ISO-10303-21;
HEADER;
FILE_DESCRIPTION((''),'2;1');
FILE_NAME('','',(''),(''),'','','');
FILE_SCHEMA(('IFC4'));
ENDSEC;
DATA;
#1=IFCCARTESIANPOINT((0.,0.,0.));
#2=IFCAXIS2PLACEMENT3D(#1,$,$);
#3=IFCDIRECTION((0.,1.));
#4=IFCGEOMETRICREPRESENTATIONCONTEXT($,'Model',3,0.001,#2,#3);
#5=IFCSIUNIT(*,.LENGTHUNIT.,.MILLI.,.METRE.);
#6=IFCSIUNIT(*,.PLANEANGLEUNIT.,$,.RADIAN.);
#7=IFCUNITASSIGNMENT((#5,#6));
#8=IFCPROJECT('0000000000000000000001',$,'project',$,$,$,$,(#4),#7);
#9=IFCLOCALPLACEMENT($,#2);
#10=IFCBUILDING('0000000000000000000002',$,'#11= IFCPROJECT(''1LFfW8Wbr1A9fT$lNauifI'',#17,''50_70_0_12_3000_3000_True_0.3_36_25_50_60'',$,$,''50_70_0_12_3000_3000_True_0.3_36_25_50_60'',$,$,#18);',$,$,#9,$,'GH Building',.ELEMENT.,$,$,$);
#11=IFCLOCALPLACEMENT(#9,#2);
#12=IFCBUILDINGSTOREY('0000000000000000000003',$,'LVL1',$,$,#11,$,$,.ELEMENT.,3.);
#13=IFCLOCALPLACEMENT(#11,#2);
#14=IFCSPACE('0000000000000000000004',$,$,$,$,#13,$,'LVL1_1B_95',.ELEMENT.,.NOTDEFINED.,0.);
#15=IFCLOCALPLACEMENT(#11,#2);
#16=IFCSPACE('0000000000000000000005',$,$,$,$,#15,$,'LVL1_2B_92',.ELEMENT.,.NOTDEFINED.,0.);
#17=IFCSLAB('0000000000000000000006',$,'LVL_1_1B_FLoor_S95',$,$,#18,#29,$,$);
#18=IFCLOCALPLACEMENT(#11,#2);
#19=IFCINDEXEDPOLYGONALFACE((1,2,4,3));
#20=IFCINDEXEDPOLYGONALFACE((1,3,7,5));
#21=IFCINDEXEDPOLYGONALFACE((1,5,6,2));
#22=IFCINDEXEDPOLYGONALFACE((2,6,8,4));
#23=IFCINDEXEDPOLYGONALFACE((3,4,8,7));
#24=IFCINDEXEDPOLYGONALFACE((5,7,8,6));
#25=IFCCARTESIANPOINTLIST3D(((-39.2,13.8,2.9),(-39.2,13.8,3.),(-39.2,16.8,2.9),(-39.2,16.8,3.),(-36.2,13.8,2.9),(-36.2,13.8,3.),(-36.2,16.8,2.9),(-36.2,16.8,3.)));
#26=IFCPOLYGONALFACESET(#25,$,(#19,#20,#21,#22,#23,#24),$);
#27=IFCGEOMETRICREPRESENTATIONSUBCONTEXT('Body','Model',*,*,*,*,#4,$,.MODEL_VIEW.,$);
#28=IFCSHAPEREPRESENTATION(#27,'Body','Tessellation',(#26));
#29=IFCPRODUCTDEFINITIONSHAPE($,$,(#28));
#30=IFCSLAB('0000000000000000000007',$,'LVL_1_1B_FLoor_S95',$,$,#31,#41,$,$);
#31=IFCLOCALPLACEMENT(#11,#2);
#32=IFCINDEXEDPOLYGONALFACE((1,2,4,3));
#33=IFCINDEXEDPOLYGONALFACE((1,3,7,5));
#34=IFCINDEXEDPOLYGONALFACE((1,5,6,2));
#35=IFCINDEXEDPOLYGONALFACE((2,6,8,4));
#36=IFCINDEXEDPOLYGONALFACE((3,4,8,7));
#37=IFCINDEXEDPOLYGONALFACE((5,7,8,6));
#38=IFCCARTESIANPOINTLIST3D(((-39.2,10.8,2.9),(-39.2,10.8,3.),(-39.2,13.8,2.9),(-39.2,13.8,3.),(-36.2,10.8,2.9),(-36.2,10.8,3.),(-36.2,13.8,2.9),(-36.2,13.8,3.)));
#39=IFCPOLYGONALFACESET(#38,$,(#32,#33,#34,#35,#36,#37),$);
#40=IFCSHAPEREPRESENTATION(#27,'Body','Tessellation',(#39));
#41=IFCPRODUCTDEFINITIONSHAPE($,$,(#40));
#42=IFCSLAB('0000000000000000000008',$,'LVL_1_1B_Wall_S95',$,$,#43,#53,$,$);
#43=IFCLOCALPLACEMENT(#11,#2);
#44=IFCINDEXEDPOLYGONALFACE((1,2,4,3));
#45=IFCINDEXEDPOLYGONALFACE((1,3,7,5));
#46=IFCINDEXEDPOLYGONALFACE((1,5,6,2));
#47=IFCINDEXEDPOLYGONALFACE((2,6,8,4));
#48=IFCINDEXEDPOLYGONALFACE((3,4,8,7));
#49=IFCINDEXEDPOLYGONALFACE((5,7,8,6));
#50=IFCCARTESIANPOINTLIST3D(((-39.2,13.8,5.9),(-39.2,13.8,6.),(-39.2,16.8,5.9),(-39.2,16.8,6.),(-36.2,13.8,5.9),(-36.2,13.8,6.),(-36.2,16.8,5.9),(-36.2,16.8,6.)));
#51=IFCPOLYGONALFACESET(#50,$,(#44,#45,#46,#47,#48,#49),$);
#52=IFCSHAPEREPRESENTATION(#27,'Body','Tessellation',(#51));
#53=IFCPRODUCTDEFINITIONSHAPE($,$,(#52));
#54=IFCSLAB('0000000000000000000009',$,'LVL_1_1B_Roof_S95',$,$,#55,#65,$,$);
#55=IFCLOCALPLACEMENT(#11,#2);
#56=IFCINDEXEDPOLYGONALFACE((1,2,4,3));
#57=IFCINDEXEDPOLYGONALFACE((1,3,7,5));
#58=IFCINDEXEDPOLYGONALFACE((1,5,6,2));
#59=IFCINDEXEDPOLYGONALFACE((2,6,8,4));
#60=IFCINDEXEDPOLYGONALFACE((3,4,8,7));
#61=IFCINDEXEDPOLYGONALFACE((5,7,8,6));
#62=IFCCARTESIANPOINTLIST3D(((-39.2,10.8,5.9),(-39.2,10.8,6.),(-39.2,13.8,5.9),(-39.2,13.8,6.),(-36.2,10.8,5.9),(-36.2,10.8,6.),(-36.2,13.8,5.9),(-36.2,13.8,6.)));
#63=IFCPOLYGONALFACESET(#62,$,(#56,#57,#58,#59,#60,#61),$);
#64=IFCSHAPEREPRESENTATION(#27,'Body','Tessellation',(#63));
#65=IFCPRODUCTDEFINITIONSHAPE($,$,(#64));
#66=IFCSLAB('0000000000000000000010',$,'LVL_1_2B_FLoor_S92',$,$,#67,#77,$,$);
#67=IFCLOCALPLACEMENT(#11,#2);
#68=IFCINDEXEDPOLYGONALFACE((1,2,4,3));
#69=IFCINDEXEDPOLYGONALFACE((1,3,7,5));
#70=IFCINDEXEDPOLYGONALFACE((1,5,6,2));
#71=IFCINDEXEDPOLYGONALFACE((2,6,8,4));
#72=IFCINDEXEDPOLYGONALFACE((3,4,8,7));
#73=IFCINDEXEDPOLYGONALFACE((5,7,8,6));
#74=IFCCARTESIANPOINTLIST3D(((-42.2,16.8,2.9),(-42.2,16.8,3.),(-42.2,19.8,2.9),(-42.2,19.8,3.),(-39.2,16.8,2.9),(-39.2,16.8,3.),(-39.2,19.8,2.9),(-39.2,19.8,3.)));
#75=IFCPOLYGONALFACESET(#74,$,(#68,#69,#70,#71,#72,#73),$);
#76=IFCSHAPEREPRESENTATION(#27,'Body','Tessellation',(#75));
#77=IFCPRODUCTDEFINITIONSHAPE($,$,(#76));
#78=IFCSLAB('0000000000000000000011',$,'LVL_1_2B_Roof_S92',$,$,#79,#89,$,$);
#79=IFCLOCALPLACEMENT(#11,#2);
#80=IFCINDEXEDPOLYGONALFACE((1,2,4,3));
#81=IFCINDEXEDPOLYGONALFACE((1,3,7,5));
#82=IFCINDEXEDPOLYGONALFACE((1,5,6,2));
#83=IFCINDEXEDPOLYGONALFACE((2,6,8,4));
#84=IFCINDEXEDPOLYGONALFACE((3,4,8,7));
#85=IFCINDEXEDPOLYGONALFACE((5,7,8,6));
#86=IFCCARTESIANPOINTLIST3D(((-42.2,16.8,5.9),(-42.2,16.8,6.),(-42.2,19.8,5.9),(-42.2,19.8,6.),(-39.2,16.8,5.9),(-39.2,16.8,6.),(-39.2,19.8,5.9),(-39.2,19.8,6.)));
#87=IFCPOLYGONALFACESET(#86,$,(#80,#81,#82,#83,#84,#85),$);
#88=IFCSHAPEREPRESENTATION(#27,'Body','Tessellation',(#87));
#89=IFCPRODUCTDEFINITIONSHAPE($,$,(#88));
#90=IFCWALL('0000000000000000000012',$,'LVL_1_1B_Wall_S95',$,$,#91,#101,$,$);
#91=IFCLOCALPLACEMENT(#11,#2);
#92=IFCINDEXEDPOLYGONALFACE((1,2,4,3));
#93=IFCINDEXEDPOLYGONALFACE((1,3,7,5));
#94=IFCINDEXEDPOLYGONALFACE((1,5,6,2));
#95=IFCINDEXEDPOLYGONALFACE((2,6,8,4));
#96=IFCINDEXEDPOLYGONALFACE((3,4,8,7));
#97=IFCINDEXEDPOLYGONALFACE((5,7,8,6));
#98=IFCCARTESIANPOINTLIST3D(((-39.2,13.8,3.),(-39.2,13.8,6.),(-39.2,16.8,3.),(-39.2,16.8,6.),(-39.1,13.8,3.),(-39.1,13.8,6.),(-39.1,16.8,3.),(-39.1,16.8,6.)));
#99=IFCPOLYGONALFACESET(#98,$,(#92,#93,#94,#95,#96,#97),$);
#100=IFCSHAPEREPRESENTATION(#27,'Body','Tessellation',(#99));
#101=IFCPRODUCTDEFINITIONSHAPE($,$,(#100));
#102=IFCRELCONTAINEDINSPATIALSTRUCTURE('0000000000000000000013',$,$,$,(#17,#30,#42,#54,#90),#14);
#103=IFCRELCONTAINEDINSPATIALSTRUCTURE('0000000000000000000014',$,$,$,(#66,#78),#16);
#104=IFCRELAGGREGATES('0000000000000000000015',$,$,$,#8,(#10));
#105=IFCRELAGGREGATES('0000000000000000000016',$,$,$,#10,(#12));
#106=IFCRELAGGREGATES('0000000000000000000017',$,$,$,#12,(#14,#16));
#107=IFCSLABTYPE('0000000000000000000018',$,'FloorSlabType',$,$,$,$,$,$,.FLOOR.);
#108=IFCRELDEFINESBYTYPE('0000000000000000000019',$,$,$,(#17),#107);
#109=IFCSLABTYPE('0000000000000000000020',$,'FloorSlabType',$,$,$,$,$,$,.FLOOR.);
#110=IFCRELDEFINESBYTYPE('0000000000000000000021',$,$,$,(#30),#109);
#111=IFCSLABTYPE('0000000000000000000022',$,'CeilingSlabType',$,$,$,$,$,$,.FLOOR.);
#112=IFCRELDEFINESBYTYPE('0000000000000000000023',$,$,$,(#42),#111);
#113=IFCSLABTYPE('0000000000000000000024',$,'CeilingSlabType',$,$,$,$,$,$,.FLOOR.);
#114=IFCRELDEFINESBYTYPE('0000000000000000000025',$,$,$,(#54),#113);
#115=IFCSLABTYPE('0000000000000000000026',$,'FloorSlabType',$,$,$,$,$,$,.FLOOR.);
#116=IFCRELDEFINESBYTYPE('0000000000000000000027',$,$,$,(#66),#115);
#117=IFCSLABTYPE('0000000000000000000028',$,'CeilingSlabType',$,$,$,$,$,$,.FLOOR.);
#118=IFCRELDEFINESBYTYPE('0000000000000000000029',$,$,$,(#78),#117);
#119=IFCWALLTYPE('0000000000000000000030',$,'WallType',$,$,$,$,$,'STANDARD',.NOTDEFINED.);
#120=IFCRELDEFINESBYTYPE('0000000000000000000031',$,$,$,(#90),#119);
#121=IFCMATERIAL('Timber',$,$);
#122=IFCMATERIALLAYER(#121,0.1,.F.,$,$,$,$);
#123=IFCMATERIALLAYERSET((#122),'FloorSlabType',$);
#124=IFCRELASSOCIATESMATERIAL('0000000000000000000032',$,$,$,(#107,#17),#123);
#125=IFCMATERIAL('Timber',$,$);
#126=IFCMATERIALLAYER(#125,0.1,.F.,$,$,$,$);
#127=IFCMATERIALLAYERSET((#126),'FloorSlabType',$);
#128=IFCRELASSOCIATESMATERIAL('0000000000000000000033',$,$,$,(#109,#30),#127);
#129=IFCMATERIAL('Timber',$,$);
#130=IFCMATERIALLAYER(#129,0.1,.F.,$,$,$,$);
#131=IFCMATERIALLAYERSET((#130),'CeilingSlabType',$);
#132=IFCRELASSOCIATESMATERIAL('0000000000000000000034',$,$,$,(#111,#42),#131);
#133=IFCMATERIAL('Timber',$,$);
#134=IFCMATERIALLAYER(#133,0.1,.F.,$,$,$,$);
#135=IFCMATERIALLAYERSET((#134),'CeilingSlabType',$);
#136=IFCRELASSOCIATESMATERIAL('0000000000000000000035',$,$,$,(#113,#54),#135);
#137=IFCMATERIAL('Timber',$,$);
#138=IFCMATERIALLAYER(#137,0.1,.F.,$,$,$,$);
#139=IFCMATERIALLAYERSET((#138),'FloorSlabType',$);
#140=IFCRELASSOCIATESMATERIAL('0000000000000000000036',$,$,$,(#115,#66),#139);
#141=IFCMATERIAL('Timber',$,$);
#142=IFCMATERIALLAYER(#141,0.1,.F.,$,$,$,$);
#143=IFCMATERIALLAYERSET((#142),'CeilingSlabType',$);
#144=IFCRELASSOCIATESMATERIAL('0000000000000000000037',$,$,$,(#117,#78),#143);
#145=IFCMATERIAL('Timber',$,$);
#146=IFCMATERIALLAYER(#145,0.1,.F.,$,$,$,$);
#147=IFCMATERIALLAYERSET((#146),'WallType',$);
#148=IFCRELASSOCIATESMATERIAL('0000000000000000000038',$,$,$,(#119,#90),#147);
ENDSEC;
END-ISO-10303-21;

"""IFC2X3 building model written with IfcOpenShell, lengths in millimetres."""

from ifc_helpers import new_model, si_unit, direction, frame, frame_2d, origin, place, context, subcontext, project, spatial, rectangle, extrude, material, layer, layer_set, layer_usage, type_object, element, save


model = new_model("IFC2X3")

# Units and contexts
model_context = context("Model", 3, precision=0.001, world=origin(), true_north=direction((0.0, 1.0)))
body_context = subcontext(model_context, "Body", "Model", "MODEL_VIEW")
ifc_project = project(units=[si_unit("LENGTHUNIT", "METRE", prefix="MILLI"), si_unit("PLANEANGLEUNIT", "RADIAN")], contexts=[model_context])

# Building, storey
building_placement = place(None, origin())
building = spatial("IfcBuilding", under=ifc_project, at=building_placement, Name="#11= IFCPROJECT('1LFfW8Wbr1A9fT$lNauifI',#17,'50_70_0_12_3000_3000_True_0.3_36_25_50_60',$,$,'50_70_0_12_3000_3000_True_0.3_36_25_50_60',$,$,#18);", LongName="GH Building", CompositionType="ELEMENT")
storey_placement = place(building_placement, origin())
storey = spatial("IfcBuildingStorey", under=building, at=storey_placement, Name="LVL1", CompositionType="ELEMENT", Elevation=3.0)

# Shared definitions
space_1_placement = place(storey_placement, origin())
space_1 = spatial("IfcSpace", under=storey, at=space_1_placement, LongName="LVL1_1B_95", CompositionType="ELEMENT", InteriorOrExteriorSpace="NOTDEFINED", ElevationWithFlooring=0.0)

# Slabs
ifc_material_1 = material(Name="Timber")
ifc_layer_1 = layer(ifc_material_1, 0.1, ventilated=False)
ifc_layer_set_1 = layer_set([ifc_layer_1], Name="FloorSlabType")
ifc_layer_usage_1 = layer_usage(ifc_layer_set_1, "AXIS3", "NEGATIVE", -0.1)
slab_type_1 = type_object("IfcSlabType", Name="FloorSlabType", PredefinedType="FLOOR", material=ifc_layer_set_1)
slab_1_placement = place(space_1_placement, frame((-39.2, 16.8, 2.9), z_axis=(0.0, 0.0, 1.0), x_axis=(0.0, -1.0, 0.0)))
element("IfcSlab", 1, at=slab_1_placement, inside=space_1, type_object=slab_type_1, material=ifc_layer_usage_1, Name="LVL_1_1B_FLoor_S95", context=body_context, shape_type="SweptSolid", body=[
    extrude(rectangle(XDim=3.0, YDim=3.0, at=frame_2d((1.5, 1.5))), origin(), (0.0, 0.0, 1.0), 0.1),
])
ifc_material_2 = material(Name="Timber")
ifc_layer_2 = layer(ifc_material_2, 0.1, ventilated=False)
ifc_layer_set_2 = layer_set([ifc_layer_2], Name="FloorSlabType")
ifc_layer_usage_2 = layer_usage(ifc_layer_set_2, "AXIS3", "NEGATIVE", -0.1)
slab_type_2 = type_object("IfcSlabType", Name="FloorSlabType", PredefinedType="FLOOR", material=ifc_layer_set_2)
slab_2_placement = place(space_1_placement, frame((-39.2, 13.8, 2.9), z_axis=(0.0, 0.0, 1.0), x_axis=(0.0, -1.0, 0.0)))
element("IfcSlab", 2, at=slab_2_placement, inside=space_1, type_object=slab_type_2, material=ifc_layer_usage_2, Name="LVL_1_1B_FLoor_S95", context=body_context, shape_type="SweptSolid", body=[
    extrude(rectangle(XDim=3.0, YDim=3.0, at=frame_2d((1.5, 1.5))), origin(), (0.0, 0.0, 1.0), 0.1),
])
ifc_material_3 = material(Name="Timber")
ifc_layer_3 = layer(ifc_material_3, 0.1, ventilated=False)
ifc_layer_set_3 = layer_set([ifc_layer_3], Name="CeilingSlabType")
ifc_layer_usage_3 = layer_usage(ifc_layer_set_3, "AXIS3", "NEGATIVE", -0.1)
slab_type_3 = type_object("IfcSlabType", Name="CeilingSlabType", PredefinedType="FLOOR", material=ifc_layer_set_3)
slab_3_placement = place(space_1_placement, frame((-39.2, 16.8, 5.9), z_axis=(0.0, 0.0, 1.0), x_axis=(0.0, -1.0, 0.0)))
element("IfcSlab", 3, at=slab_3_placement, inside=space_1, type_object=slab_type_3, material=ifc_layer_usage_3, Name="LVL_1_1B_Wall_S95", context=body_context, shape_type="SweptSolid", body=[
    extrude(rectangle(XDim=3.0, YDim=3.0, at=frame_2d((1.5, 1.5))), origin(), (0.0, 0.0, 1.0), 0.1),
])
ifc_material_4 = material(Name="Timber")
ifc_layer_4 = layer(ifc_material_4, 0.1, ventilated=False)
ifc_layer_set_4 = layer_set([ifc_layer_4], Name="CeilingSlabType")
ifc_layer_usage_4 = layer_usage(ifc_layer_set_4, "AXIS3", "NEGATIVE", -0.1)
slab_type_4 = type_object("IfcSlabType", Name="CeilingSlabType", PredefinedType="FLOOR", material=ifc_layer_set_4)
slab_4_placement = place(space_1_placement, frame((-39.2, 13.8, 5.9), z_axis=(0.0, 0.0, 1.0), x_axis=(0.0, -1.0, 0.0)))
element("IfcSlab", 4, at=slab_4_placement, inside=space_1, type_object=slab_type_4, material=ifc_layer_usage_4, Name="LVL_1_1B_Roof_S95", context=body_context, shape_type="SweptSolid", body=[
    extrude(rectangle(XDim=3.0, YDim=3.0, at=frame_2d((1.5, 1.5))), origin(), (0.0, 0.0, 1.0), 0.1),
])

# Shared definitions
space_2_placement = place(storey_placement, origin())
space_2 = spatial("IfcSpace", under=storey, at=space_2_placement, LongName="LVL1_2B_92", CompositionType="ELEMENT", InteriorOrExteriorSpace="NOTDEFINED", ElevationWithFlooring=0.0)

# Slabs
ifc_material_5 = material(Name="Timber")
ifc_layer_5 = layer(ifc_material_5, 0.1, ventilated=False)
ifc_layer_set_5 = layer_set([ifc_layer_5], Name="FloorSlabType")
ifc_layer_usage_5 = layer_usage(ifc_layer_set_5, "AXIS3", "NEGATIVE", -0.1)
slab_type_5 = type_object("IfcSlabType", Name="FloorSlabType", PredefinedType="FLOOR", material=ifc_layer_set_5)
slab_5_placement = place(space_2_placement, frame((-42.2, 19.8, 2.9), z_axis=(0.0, 0.0, 1.0), x_axis=(0.0, -1.0, 0.0)))
element("IfcSlab", 5, at=slab_5_placement, inside=space_2, type_object=slab_type_5, material=ifc_layer_usage_5, Name="LVL_1_2B_FLoor_S92", context=body_context, shape_type="SweptSolid", body=[
    extrude(rectangle(XDim=3.0, YDim=3.0, at=frame_2d((1.5, 1.5))), origin(), (0.0, 0.0, 1.0), 0.1),
])
ifc_material_6 = material(Name="Timber")
ifc_layer_6 = layer(ifc_material_6, 0.1, ventilated=False)
ifc_layer_set_6 = layer_set([ifc_layer_6], Name="CeilingSlabType")
ifc_layer_usage_6 = layer_usage(ifc_layer_set_6, "AXIS3", "NEGATIVE", -0.1)
slab_type_6 = type_object("IfcSlabType", Name="CeilingSlabType", PredefinedType="FLOOR", material=ifc_layer_set_6)
slab_6_placement = place(space_2_placement, frame((-42.2, 19.8, 5.9), z_axis=(0.0, 0.0, 1.0), x_axis=(0.0, -1.0, 0.0)))
element("IfcSlab", 6, at=slab_6_placement, inside=space_2, type_object=slab_type_6, material=ifc_layer_usage_6, Name="LVL_1_2B_Roof_S92", context=body_context, shape_type="SweptSolid", body=[
    extrude(rectangle(XDim=3.0, YDim=3.0, at=frame_2d((1.5, 1.5))), origin(), (0.0, 0.0, 1.0), 0.1),
])

# Wall
ifc_material_7 = material(Name="Timber")
ifc_layer_7 = layer(ifc_material_7, 0.1, ventilated=False)
ifc_layer_set_7 = layer_set([ifc_layer_7], Name="WallType")
ifc_layer_usage_7 = layer_usage(ifc_layer_set_7, "AXIS2", "NEGATIVE", 0.0)
wall_type_1 = type_object("IfcWallType", Name="WallType", ElementType="STANDARD", PredefinedType="NOTDEFINED", material=ifc_layer_set_7)
wall_1_placement = place(space_1_placement, frame((-39.2, 13.8, 3.0), z_axis=(0.0, 0.0, 1.0), x_axis=(0.0, 1.0, 0.0)))
element("IfcWall", 7, at=wall_1_placement, inside=space_1, type_object=wall_type_1, material=ifc_layer_usage_7, Name="LVL_1_1B_Wall_S95", context=body_context, shape_type="SweptSolid", body=[
    extrude(rectangle(XDim=3.0, YDim=0.1, at=frame_2d((1.5, -0.1))), origin(), (0.0, 0.0, 1.0), 3.0),
])

save(model, "model.ifc")
